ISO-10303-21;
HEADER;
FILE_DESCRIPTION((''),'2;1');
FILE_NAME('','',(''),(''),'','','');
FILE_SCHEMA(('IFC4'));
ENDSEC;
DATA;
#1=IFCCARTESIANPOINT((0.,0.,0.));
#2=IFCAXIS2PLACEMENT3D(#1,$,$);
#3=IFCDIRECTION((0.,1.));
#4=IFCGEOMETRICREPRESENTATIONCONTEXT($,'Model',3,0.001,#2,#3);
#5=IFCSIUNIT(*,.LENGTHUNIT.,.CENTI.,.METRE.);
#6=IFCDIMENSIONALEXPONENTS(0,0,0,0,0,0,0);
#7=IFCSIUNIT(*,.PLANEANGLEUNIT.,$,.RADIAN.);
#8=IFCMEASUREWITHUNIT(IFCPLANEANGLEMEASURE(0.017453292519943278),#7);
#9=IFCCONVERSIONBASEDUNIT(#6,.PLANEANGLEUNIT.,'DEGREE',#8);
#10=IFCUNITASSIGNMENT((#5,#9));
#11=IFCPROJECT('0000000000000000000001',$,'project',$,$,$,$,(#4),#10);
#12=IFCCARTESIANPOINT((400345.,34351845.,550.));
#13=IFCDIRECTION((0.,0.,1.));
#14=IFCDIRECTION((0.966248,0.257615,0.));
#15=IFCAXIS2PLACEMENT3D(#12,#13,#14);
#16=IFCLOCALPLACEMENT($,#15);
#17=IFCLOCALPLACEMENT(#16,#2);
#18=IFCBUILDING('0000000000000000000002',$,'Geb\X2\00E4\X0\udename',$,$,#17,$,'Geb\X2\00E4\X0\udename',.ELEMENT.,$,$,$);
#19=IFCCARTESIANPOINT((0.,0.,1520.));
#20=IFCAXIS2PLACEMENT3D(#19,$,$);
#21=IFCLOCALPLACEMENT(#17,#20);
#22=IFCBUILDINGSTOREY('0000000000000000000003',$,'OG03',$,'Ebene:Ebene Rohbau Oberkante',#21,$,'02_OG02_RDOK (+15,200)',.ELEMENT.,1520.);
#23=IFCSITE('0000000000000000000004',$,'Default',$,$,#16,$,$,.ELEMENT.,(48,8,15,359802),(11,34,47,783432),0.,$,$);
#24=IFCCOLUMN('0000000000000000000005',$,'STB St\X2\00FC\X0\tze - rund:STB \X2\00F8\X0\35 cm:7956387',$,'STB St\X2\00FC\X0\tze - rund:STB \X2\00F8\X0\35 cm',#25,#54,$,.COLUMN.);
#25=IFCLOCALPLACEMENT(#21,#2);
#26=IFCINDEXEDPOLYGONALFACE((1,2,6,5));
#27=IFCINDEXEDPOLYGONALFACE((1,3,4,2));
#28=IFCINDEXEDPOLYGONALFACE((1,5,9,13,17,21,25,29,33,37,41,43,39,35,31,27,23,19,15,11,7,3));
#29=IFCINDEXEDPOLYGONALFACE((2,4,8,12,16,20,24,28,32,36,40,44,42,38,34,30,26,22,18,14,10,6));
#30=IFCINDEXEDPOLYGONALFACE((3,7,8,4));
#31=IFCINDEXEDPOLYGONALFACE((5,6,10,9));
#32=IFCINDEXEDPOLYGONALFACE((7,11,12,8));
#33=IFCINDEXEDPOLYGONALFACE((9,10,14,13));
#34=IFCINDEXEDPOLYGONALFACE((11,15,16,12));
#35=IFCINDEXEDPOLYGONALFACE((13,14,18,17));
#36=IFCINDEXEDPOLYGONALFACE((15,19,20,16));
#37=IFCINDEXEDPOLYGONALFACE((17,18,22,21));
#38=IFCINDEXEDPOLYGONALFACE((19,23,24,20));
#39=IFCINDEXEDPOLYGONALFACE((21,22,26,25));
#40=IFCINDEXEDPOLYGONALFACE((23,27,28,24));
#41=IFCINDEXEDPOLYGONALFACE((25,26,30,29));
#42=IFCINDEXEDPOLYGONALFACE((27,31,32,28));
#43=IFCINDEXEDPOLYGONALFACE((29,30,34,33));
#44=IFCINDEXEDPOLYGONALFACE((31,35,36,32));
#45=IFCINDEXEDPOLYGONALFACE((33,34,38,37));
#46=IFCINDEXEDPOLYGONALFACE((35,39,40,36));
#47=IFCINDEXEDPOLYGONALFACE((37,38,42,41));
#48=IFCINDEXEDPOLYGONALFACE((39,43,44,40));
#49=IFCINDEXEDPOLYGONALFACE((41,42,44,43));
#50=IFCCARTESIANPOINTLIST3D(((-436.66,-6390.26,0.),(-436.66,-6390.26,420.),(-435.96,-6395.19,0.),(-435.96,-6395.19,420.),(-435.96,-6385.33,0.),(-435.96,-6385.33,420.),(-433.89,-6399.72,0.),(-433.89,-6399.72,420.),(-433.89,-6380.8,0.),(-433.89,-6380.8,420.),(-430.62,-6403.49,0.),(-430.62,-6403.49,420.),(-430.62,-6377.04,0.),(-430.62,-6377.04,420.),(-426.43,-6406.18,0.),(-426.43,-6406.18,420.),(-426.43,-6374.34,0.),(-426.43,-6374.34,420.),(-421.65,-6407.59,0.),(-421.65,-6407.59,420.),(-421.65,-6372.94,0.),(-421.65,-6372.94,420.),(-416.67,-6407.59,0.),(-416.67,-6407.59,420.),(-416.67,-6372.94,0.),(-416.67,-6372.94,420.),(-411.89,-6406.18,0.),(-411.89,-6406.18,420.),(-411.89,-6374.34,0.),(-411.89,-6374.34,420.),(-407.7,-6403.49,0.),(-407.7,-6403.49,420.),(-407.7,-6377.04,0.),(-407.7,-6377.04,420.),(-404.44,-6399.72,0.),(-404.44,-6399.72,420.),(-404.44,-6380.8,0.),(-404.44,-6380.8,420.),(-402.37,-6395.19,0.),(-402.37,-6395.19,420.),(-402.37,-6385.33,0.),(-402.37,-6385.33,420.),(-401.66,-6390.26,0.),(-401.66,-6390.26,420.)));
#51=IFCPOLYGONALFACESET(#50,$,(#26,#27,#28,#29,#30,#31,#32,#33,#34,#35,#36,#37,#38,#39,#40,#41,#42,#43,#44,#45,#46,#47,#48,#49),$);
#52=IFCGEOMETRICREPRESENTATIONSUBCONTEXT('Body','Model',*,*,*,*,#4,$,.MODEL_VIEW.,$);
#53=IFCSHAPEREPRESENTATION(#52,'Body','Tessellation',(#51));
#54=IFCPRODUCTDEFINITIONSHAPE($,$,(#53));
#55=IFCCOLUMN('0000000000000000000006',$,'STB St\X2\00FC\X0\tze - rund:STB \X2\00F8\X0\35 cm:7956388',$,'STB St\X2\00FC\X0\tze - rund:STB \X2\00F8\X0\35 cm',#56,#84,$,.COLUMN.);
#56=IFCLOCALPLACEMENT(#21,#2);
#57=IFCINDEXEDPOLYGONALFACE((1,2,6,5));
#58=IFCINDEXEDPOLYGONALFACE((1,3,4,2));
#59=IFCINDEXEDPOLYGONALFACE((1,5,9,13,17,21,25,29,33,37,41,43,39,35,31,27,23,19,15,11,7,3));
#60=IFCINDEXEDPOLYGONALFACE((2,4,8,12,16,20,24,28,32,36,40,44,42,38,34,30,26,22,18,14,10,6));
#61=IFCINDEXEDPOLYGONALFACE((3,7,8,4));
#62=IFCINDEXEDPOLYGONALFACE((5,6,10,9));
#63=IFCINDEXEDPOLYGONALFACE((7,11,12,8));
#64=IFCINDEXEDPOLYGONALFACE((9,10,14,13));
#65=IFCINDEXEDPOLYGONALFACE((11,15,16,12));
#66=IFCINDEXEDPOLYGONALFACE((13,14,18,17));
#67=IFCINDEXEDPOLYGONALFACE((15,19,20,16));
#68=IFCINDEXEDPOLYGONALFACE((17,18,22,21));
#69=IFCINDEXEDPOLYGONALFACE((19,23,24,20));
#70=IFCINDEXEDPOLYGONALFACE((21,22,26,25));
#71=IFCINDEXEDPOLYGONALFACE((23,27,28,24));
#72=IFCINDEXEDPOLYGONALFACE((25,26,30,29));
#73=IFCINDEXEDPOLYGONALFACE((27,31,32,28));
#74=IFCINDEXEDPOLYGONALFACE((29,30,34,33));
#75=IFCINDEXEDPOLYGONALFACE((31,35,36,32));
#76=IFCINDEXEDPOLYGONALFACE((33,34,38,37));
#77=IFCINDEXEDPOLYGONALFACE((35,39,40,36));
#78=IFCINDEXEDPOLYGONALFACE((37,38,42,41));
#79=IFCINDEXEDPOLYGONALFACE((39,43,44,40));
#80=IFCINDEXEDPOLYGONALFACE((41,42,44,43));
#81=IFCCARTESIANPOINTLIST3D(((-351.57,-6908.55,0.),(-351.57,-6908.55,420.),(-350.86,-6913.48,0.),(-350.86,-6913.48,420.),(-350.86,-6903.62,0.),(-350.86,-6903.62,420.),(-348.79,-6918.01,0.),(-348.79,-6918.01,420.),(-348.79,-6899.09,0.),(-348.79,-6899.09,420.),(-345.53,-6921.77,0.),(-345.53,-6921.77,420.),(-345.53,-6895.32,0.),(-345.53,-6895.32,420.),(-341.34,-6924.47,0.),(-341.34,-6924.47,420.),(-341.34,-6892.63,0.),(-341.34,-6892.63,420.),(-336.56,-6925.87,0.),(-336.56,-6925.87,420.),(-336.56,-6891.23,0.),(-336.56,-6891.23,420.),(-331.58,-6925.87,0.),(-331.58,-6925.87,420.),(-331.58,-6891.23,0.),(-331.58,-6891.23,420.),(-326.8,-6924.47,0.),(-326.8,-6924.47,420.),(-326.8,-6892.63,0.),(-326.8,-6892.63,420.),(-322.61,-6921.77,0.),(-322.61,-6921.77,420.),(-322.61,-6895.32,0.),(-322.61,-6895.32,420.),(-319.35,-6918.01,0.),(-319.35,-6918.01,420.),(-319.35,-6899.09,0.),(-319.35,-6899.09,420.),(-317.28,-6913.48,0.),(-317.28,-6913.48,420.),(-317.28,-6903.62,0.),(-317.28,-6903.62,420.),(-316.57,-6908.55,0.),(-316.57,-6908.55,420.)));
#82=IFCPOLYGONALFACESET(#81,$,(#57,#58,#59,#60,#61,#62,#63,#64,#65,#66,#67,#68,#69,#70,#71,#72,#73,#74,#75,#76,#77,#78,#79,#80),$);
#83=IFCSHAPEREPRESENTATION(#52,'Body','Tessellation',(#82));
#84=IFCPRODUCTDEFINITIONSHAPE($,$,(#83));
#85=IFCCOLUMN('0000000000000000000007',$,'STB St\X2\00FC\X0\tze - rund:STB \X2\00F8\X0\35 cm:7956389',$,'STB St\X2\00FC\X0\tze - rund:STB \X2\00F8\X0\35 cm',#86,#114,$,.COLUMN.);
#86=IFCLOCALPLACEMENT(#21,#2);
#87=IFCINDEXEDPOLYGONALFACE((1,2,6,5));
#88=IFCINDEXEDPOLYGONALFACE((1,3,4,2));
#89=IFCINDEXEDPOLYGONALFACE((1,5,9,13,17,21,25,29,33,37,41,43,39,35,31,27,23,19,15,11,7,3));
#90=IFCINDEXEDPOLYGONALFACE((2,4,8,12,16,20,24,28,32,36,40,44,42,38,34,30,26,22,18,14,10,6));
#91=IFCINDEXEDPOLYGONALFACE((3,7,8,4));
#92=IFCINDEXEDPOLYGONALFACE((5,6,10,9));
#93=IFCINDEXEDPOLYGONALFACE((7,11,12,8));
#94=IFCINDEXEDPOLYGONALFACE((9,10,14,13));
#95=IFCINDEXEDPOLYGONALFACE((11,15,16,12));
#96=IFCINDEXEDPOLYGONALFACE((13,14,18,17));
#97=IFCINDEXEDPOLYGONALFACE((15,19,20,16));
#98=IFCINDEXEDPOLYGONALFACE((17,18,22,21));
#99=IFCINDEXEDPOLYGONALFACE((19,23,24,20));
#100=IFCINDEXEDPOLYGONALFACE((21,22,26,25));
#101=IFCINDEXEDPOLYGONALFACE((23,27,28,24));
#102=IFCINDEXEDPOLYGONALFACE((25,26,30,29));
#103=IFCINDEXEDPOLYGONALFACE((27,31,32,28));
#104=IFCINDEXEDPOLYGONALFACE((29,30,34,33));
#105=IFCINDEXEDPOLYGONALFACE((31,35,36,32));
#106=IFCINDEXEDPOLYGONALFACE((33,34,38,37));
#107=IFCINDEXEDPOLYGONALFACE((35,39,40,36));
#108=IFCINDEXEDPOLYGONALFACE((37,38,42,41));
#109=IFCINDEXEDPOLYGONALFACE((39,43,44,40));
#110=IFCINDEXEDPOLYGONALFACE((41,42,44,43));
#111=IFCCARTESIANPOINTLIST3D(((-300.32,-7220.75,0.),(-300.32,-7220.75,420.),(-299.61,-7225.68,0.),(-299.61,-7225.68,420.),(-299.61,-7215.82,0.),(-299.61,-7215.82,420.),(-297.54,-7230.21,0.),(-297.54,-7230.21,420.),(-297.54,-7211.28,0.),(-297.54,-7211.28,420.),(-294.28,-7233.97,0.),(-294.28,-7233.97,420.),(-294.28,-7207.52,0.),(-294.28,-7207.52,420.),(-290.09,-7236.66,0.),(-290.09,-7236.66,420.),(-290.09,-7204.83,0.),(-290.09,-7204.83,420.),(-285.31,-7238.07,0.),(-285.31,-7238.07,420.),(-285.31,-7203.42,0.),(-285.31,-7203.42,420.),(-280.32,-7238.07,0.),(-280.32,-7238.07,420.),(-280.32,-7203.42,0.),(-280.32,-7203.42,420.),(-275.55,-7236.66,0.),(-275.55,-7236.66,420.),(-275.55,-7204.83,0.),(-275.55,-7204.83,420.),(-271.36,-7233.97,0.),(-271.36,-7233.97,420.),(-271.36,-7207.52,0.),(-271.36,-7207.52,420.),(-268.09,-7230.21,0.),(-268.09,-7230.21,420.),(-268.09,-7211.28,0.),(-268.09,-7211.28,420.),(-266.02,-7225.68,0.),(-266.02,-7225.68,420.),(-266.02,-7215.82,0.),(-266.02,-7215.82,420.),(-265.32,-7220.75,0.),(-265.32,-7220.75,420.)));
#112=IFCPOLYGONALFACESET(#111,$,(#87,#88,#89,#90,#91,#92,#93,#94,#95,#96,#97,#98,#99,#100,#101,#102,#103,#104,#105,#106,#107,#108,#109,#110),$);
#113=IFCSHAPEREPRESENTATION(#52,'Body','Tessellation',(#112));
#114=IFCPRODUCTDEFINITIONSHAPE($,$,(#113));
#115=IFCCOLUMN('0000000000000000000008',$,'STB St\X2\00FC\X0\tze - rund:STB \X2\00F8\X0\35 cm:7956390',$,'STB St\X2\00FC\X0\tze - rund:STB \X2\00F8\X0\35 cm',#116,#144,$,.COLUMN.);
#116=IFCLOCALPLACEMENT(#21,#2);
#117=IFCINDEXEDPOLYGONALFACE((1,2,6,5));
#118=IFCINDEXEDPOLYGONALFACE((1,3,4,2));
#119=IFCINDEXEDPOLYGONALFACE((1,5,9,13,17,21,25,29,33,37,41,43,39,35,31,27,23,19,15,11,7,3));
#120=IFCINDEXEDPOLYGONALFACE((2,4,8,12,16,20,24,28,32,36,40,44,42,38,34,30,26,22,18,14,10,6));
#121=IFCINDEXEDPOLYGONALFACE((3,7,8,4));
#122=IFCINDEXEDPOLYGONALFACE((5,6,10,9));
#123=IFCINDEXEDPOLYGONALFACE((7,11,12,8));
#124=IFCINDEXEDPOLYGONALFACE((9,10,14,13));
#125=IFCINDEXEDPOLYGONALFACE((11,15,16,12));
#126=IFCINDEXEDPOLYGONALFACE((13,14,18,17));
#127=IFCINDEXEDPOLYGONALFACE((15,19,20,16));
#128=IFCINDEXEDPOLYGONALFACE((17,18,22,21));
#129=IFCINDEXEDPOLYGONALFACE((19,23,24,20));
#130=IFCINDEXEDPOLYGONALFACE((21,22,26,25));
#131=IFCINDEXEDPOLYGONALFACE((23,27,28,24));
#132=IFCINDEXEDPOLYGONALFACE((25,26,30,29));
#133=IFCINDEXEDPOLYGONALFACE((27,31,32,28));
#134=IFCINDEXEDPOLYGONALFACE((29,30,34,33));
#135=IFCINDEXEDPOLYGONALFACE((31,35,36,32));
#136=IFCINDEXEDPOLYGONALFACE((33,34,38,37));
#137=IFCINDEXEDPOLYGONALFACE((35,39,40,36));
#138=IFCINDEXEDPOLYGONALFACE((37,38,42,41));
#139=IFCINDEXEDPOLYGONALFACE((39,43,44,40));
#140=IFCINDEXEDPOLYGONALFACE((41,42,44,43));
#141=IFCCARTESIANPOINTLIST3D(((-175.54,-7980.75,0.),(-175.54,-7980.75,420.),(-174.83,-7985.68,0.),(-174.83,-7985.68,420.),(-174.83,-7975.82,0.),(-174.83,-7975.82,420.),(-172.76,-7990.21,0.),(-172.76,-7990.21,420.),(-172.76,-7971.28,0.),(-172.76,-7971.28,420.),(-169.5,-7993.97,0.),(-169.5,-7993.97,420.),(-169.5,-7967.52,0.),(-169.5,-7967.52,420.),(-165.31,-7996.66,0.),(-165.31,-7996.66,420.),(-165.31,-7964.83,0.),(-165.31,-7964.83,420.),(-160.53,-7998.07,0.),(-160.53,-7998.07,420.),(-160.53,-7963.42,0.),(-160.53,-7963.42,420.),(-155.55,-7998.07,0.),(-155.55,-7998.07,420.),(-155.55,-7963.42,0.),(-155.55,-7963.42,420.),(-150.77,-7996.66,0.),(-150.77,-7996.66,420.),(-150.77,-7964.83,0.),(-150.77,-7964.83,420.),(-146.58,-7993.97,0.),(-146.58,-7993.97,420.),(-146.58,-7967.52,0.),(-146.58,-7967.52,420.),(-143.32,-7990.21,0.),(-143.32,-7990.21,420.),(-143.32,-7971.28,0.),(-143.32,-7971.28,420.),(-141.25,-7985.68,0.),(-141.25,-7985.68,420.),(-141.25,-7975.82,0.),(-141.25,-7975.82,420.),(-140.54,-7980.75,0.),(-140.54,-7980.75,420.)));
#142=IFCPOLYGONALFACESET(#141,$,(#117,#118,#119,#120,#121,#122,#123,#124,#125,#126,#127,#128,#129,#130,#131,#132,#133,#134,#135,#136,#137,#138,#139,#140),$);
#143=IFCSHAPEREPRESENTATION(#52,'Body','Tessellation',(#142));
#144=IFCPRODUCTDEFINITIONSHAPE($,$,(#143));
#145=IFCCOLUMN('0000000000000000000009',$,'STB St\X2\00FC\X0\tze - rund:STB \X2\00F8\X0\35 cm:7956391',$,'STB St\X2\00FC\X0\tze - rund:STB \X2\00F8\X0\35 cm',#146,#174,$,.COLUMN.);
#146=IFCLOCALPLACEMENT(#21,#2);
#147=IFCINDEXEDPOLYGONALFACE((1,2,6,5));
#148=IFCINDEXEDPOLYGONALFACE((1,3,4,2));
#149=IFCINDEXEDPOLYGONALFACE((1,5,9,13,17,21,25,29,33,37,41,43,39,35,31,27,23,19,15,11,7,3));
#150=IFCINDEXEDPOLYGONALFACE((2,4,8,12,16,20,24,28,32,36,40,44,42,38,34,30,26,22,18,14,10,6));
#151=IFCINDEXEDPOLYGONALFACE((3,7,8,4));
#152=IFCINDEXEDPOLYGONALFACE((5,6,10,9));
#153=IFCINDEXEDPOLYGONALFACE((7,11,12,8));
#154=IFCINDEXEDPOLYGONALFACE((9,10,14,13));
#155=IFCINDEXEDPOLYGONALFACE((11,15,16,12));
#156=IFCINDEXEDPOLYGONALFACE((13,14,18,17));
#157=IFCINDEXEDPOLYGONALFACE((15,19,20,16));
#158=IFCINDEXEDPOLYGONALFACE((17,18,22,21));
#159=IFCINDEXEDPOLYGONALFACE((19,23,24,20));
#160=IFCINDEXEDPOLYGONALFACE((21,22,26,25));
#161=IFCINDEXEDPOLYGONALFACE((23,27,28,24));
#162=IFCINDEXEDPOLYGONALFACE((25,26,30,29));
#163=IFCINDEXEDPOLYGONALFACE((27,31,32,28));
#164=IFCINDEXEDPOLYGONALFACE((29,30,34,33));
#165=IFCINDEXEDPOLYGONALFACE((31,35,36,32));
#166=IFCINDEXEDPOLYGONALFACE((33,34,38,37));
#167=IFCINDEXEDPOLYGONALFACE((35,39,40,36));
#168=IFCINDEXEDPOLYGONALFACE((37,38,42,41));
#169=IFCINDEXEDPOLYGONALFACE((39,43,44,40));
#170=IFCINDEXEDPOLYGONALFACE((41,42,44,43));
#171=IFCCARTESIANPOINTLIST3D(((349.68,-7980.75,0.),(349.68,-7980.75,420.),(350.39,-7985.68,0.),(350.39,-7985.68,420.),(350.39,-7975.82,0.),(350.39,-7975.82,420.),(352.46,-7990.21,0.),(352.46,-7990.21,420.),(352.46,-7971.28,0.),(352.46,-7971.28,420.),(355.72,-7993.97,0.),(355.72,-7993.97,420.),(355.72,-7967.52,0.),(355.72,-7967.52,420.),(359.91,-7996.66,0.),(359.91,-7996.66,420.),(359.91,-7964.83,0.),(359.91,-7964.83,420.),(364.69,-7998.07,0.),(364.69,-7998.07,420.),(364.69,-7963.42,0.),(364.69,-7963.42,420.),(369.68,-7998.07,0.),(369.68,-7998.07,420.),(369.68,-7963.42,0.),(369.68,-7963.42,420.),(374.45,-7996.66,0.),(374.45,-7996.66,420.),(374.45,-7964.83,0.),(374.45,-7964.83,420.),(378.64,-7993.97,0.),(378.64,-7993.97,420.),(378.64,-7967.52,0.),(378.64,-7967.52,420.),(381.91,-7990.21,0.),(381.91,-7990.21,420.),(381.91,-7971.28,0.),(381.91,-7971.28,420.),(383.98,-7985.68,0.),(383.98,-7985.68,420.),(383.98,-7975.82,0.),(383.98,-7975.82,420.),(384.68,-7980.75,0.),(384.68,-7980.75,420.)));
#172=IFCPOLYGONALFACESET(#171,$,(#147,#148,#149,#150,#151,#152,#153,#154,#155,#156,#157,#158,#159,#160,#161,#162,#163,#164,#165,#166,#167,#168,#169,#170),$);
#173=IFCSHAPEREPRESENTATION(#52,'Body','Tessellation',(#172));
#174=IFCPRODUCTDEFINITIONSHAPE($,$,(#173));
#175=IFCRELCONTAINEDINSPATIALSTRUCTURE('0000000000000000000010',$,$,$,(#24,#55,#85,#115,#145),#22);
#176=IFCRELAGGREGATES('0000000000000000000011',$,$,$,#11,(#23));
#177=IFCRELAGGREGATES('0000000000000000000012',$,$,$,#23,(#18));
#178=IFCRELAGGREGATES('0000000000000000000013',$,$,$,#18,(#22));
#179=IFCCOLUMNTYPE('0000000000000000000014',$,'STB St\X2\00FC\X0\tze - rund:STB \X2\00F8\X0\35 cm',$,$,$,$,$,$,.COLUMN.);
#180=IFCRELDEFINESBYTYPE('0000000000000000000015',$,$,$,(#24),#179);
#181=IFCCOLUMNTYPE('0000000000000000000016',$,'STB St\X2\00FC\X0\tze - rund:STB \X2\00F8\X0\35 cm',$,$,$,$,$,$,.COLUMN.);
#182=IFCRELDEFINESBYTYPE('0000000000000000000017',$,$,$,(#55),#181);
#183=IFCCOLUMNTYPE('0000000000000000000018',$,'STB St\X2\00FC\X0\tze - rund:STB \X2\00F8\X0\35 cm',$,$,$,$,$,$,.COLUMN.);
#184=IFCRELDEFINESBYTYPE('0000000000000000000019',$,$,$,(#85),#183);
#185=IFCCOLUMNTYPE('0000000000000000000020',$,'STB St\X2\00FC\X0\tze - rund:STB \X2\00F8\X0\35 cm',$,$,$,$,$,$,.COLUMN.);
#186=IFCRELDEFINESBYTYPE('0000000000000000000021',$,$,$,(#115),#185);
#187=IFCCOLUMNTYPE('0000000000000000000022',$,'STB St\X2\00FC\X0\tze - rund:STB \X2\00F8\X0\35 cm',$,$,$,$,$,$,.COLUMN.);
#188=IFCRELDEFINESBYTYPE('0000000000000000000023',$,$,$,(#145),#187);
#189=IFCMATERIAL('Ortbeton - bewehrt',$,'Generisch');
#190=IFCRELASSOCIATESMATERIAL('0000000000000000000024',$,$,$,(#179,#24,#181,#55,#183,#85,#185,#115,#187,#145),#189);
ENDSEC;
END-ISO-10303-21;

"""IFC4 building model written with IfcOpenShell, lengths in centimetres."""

from ifc_helpers import new_model, entity, si_unit, converted_unit, direction, frame, origin, place, context, subcontext, project, spatial, arc, indexed_curve, outline, extrude, source, transform, mapped, material, type_object, type_shapes, element, save


model = new_model("IFC4")

# Units and contexts
model_context = context("Model", 3, precision=0.001, world=origin(), true_north=direction((0.0, 1.0)))
body_context = subcontext(model_context, "Body", "Model", "MODEL_VIEW")
ifc_project = project(units=[si_unit("LENGTHUNIT", "METRE", prefix="CENTI"), converted_unit("PLANEANGLEUNIT", "DEGREE", entity("IfcPlaneAngleMeasure", 0.017453292519943278), si_unit("PLANEANGLEUNIT", "RADIAN"), dimensions=[0, 0, 0, 0, 0, 0, 0])], contexts=[model_context])

# Site, building, storey
site_placement = place(None, frame((400345.0, 34351845.0, 550.0), z_axis=(0.0, 0.0, 1.0), x_axis=(0.966248, 0.257615, 0.0)))
site = spatial("IfcSite", under=ifc_project, at=site_placement, Name="Default", CompositionType="ELEMENT", RefLatitude=(48, 8, 15, 359802), RefLongitude=(11, 34, 47, 783432), RefElevation=0.0)
building_placement = place(site_placement, origin())
building = spatial("IfcBuilding", under=site, at=building_placement, Name="Gebäudename", LongName="Gebäudename", CompositionType="ELEMENT")
storey_placement = place(building_placement, frame((0.0, 0.0, 1520.0)))
storey = spatial("IfcBuildingStorey", under=building, at=storey_placement, Name="OG03", ObjectType="Ebene:Ebene Rohbau Oberkante", LongName="02_OG02_RDOK (+15,200)", CompositionType="ELEMENT", Elevation=1520.0)

# Columns
ifc_material = material(Name="Ortbeton - bewehrt", Category="Generisch")
column_type_1 = type_object("IfcColumnType", Name="STB Stütze - rund:STB ø35 cm", PredefinedType="COLUMN", material=ifc_material)
shared_shape_1 = source(origin(), body_context, "Body", "SweptSolid", [
    extrude(outline(indexed_curve([(-17.5, 0.0), (0.0, -17.5), (17.5, 0.0), (0.0, 17.5)], segments=[arc(1, 2, 3), arc(3, 4, 1)], self_intersect=False)), frame((-419.16, -6390.26, 1520.0)), (0.0, 0.0, 1.0), 420.0),
])
type_shapes(column_type_1, [shared_shape_1])
column_1_placement = place(storey_placement, frame((0.0, 0.0, -1520.0)))
element("IfcColumn", 1, at=column_1_placement, inside=storey, type_object=column_type_1, material=ifc_material, Name="STB Stütze - rund:STB ø35 cm:7956387", ObjectType="STB Stütze - rund:STB ø35 cm", PredefinedType="COLUMN", context=body_context, shape_type="MappedRepresentation", body=[
    mapped(shared_shape_1, transform((0.0, 0.0, 0.0), scale=1.0)),
])
column_type_2 = type_object("IfcColumnType", Name="STB Stütze - rund:STB ø35 cm", PredefinedType="COLUMN", material=ifc_material)
shared_shape_2 = source(origin(), body_context, "Body", "SweptSolid", [
    extrude(outline(indexed_curve([(-17.5, 0.0), (0.0, -17.5), (17.5, 0.0), (0.0, 17.5)], segments=[arc(1, 2, 3), arc(3, 4, 1)], self_intersect=False)), frame((-334.07, -6908.55, 1520.0)), (0.0, 0.0, 1.0), 420.0),
])
type_shapes(column_type_2, [shared_shape_2])
column_2_placement = place(storey_placement, frame((0.0, 0.0, -1520.0)))
element("IfcColumn", 2, at=column_2_placement, inside=storey, type_object=column_type_2, material=ifc_material, Name="STB Stütze - rund:STB ø35 cm:7956388", ObjectType="STB Stütze - rund:STB ø35 cm", PredefinedType="COLUMN", context=body_context, shape_type="MappedRepresentation", body=[
    mapped(shared_shape_2, transform((0.0, 0.0, 0.0), scale=1.0)),
])
column_type_3 = type_object("IfcColumnType", Name="STB Stütze - rund:STB ø35 cm", PredefinedType="COLUMN", material=ifc_material)
shared_shape_3 = source(origin(), body_context, "Body", "SweptSolid", [
    extrude(outline(indexed_curve([(-17.5, 0.0), (0.0, -17.5), (17.5, 0.0), (0.0, 17.5)], segments=[arc(1, 2, 3), arc(3, 4, 1)], self_intersect=False)), frame((-282.82, -7220.75, 1520.0)), (0.0, 0.0, 1.0), 420.0),
])
type_shapes(column_type_3, [shared_shape_3])
column_3_placement = place(storey_placement, frame((0.0, 0.0, -1520.0)))
element("IfcColumn", 3, at=column_3_placement, inside=storey, type_object=column_type_3, material=ifc_material, Name="STB Stütze - rund:STB ø35 cm:7956389", ObjectType="STB Stütze - rund:STB ø35 cm", PredefinedType="COLUMN", context=body_context, shape_type="MappedRepresentation", body=[
    mapped(shared_shape_3, transform((0.0, 0.0, 0.0), scale=1.0)),
])
column_type_4 = type_object("IfcColumnType", Name="STB Stütze - rund:STB ø35 cm", PredefinedType="COLUMN", material=ifc_material)
shared_shape_4 = source(origin(), body_context, "Body", "SweptSolid", [
    extrude(outline(indexed_curve([(-17.5, 0.0), (0.0, -17.5), (17.5, 0.0), (0.0, 17.5)], segments=[arc(1, 2, 3), arc(3, 4, 1)], self_intersect=False)), frame((-158.04, -7980.75, 1520.0)), (0.0, 0.0, 1.0), 420.0),
])
type_shapes(column_type_4, [shared_shape_4])
column_4_placement = place(storey_placement, frame((0.0, 0.0, -1520.0)))
element("IfcColumn", 4, at=column_4_placement, inside=storey, type_object=column_type_4, material=ifc_material, Name="STB Stütze - rund:STB ø35 cm:7956390", ObjectType="STB Stütze - rund:STB ø35 cm", PredefinedType="COLUMN", context=body_context, shape_type="MappedRepresentation", body=[
    mapped(shared_shape_4, transform((0.0, 0.0, 0.0), scale=1.0)),
])
column_type_5 = type_object("IfcColumnType", Name="STB Stütze - rund:STB ø35 cm", PredefinedType="COLUMN", material=ifc_material)
shared_shape_5 = source(origin(), body_context, "Body", "SweptSolid", [
    extrude(outline(indexed_curve([(-17.5, 0.0), (0.0, -17.5), (17.5, 0.0), (0.0, 17.5)], segments=[arc(1, 2, 3), arc(3, 4, 1)], self_intersect=False)), frame((367.18, -7980.75, 1520.0)), (0.0, 0.0, 1.0), 420.0),
])
type_shapes(column_type_5, [shared_shape_5])
column_5_placement = place(storey_placement, frame((0.0, 0.0, -1520.0)))
element("IfcColumn", 5, at=column_5_placement, inside=storey, type_object=column_type_5, material=ifc_material, Name="STB Stütze - rund:STB ø35 cm:7956391", ObjectType="STB Stütze - rund:STB ø35 cm", PredefinedType="COLUMN", context=body_context, shape_type="MappedRepresentation", body=[
    mapped(shared_shape_5, transform((0.0, 0.0, 0.0), scale=1.0)),
])

save(model, "model.ifc")
